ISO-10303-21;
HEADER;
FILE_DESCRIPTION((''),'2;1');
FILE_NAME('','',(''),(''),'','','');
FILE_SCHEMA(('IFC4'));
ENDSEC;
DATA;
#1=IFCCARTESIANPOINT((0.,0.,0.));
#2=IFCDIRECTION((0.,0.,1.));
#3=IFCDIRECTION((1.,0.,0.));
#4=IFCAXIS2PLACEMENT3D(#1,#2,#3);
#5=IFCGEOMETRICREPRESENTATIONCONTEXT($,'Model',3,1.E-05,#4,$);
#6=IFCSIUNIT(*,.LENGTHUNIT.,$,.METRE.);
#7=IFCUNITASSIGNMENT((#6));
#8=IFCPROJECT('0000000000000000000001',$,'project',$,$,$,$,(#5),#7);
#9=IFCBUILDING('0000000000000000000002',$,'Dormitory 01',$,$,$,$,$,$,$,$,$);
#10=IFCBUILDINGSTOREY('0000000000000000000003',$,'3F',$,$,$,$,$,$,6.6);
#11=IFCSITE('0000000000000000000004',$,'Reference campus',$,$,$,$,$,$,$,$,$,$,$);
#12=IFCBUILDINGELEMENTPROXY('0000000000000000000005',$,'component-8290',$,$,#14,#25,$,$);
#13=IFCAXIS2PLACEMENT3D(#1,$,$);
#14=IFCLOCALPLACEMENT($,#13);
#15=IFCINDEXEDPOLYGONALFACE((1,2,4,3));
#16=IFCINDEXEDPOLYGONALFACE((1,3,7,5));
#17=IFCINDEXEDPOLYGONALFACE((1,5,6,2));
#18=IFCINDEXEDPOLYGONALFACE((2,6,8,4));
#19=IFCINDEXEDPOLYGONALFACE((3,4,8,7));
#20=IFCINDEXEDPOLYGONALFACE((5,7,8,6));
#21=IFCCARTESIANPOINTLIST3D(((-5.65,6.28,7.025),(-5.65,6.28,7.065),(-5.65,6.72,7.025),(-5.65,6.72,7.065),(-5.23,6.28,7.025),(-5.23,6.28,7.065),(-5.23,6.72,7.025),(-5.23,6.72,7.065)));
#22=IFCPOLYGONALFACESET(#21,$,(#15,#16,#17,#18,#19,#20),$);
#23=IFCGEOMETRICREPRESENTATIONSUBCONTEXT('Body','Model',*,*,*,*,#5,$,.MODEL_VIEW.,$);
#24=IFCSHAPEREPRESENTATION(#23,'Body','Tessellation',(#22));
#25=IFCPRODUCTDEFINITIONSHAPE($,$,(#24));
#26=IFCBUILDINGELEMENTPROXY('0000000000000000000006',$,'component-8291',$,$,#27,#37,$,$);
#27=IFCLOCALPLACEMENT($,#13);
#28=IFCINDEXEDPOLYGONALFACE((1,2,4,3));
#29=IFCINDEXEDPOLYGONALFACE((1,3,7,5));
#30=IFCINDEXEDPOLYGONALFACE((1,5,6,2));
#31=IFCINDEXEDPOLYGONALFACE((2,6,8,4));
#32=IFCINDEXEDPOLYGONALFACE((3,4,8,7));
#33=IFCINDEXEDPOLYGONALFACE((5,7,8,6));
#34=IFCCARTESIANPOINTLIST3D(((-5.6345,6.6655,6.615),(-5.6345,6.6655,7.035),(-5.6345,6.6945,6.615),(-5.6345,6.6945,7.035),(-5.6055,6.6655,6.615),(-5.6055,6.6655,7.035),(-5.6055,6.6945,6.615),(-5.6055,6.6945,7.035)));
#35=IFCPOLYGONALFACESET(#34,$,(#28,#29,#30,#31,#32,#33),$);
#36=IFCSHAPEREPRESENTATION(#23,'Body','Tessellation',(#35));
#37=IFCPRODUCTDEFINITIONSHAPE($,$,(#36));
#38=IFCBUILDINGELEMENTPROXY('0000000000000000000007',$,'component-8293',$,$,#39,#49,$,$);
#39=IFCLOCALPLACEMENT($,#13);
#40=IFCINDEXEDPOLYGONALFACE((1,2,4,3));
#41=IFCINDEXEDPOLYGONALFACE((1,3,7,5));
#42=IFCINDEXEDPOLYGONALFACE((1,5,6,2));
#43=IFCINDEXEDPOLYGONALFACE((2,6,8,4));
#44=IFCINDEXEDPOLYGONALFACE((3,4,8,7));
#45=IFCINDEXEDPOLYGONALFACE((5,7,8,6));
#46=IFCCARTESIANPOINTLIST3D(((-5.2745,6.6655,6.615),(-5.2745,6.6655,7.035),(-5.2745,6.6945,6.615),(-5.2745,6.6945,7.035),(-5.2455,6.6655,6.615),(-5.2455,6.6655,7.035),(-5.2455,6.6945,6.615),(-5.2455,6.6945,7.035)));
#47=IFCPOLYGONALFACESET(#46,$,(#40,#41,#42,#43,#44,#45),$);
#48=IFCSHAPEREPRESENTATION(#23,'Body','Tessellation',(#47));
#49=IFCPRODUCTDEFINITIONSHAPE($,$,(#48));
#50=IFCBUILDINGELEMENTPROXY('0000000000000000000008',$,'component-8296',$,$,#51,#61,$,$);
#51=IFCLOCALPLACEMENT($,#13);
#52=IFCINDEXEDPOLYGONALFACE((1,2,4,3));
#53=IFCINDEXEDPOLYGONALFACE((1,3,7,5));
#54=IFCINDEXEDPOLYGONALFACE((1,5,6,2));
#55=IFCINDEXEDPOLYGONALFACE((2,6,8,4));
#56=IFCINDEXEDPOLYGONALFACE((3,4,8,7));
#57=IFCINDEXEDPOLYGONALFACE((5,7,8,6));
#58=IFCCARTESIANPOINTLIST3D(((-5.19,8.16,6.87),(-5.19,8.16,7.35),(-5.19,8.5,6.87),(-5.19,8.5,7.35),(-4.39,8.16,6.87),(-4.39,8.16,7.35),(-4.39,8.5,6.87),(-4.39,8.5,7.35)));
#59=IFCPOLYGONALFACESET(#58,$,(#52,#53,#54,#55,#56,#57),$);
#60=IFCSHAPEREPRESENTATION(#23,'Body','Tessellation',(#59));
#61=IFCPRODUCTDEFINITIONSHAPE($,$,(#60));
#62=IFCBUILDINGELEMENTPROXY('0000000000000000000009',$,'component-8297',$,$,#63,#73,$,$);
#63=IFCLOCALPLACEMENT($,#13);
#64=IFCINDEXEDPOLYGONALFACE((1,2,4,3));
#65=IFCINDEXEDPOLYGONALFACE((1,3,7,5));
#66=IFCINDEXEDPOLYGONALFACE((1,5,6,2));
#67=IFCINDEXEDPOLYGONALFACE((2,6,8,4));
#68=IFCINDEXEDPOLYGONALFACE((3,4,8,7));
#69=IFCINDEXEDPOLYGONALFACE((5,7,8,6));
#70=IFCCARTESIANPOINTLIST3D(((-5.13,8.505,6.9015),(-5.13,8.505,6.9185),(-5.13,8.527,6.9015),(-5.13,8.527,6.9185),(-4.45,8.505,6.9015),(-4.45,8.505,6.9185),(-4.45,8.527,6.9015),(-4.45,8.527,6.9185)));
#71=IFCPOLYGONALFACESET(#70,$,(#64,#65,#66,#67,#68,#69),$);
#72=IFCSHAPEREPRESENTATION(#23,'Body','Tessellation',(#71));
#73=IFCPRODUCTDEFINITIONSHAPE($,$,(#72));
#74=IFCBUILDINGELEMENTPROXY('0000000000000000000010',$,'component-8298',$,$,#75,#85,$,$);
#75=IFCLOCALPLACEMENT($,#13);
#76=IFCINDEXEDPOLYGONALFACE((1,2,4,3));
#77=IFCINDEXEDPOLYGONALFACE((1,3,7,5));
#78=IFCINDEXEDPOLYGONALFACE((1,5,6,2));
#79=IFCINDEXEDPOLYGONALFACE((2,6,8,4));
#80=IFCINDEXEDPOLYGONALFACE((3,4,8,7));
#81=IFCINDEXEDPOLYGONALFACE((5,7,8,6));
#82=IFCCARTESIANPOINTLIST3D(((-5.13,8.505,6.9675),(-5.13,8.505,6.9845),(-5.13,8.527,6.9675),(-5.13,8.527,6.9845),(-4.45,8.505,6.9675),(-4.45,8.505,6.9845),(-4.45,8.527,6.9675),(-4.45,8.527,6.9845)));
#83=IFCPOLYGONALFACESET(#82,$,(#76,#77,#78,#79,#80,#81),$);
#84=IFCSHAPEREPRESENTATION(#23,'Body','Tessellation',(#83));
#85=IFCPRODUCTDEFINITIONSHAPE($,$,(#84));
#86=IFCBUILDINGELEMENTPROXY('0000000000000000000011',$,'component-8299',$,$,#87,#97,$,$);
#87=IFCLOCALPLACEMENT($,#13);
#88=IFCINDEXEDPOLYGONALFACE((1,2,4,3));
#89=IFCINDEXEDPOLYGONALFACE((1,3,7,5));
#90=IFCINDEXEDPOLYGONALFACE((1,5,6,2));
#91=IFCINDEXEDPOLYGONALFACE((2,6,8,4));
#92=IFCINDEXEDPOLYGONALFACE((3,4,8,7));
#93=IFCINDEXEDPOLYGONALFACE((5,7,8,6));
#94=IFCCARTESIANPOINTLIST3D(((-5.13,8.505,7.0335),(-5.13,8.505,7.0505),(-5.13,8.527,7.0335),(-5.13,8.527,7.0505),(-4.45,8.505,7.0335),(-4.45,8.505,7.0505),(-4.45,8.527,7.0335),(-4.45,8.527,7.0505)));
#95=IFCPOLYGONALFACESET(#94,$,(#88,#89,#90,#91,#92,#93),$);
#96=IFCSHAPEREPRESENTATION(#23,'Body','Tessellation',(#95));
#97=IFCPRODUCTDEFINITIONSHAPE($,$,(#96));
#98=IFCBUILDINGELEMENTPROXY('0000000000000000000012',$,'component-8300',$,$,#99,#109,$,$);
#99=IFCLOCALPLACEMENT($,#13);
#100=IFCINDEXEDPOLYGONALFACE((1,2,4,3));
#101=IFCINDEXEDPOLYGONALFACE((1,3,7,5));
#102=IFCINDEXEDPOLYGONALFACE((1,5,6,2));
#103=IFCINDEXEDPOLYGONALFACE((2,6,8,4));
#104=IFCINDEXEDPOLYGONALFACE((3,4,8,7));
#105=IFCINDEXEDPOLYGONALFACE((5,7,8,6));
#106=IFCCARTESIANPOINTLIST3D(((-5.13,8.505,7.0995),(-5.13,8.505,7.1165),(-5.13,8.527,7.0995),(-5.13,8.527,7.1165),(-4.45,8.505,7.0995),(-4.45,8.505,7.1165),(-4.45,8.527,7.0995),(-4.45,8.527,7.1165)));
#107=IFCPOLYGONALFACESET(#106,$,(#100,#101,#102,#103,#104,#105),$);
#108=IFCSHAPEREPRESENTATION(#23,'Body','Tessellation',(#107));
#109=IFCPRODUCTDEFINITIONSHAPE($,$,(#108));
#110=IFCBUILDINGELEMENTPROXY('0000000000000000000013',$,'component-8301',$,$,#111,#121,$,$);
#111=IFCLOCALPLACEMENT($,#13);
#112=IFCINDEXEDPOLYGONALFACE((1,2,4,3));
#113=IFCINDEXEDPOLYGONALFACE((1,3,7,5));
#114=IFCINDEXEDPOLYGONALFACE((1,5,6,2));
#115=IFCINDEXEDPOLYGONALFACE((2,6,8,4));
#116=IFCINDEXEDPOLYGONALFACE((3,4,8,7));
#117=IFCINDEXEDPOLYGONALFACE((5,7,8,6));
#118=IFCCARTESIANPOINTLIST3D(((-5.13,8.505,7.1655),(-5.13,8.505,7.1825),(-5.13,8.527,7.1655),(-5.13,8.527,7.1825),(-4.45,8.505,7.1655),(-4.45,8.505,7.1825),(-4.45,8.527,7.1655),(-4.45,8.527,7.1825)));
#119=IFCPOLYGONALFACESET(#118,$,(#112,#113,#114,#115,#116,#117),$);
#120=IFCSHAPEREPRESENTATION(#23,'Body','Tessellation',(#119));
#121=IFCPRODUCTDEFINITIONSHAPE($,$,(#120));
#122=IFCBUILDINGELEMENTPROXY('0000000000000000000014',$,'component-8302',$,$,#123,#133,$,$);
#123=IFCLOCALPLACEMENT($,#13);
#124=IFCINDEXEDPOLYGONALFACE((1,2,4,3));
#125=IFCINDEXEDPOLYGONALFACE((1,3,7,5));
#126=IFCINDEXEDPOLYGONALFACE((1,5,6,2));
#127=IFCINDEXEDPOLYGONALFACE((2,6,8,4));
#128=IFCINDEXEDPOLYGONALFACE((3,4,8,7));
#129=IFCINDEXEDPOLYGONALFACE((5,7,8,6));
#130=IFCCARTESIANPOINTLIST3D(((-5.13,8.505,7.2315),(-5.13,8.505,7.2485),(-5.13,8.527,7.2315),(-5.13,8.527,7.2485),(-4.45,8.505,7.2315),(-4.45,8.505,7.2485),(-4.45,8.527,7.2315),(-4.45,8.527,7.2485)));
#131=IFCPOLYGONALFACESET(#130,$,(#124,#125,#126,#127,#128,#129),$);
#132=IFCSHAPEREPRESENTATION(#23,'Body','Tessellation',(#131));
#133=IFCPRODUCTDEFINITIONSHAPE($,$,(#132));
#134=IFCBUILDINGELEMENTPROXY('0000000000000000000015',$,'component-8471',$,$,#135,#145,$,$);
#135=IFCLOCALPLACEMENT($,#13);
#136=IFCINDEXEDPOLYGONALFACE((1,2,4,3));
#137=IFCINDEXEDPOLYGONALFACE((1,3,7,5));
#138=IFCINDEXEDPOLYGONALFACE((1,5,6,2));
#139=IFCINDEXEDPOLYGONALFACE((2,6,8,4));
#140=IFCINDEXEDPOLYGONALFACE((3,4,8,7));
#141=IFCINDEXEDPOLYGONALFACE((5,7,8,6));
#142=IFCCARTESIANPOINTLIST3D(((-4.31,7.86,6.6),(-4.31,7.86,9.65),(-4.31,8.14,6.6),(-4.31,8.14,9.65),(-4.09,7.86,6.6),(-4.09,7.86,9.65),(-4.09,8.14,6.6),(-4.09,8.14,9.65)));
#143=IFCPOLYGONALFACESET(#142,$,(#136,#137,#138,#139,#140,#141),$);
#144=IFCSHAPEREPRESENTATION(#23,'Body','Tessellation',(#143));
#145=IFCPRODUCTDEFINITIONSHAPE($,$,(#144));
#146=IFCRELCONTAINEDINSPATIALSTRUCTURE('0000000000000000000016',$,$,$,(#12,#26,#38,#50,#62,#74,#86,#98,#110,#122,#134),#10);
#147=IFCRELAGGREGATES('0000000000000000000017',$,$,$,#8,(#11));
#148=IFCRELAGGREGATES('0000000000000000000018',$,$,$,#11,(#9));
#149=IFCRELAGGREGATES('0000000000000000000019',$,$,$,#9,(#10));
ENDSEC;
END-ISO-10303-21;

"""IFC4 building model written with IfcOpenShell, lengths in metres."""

from ifc_helpers import new_model, si_unit, frame, origin, origin_with_axes, origin_2d, place, context, subcontext, project, spatial, rectangle, extrude, element, save


model = new_model("IFC4")

# Units and contexts
model_context = context("Model", 3, precision=1e-05, world=origin_with_axes())
body_context = subcontext(model_context, "Body", "Model", "MODEL_VIEW")
ifc_project = project(units=[si_unit("LENGTHUNIT", "METRE")], contexts=[model_context])

# Site, building, storey
site = spatial("IfcSite", under=ifc_project, Name="Reference campus")
building = spatial("IfcBuilding", under=site, Name="Dormitory 01")
storey = spatial("IfcBuildingStorey", under=building, Name="3F", Elevation=6.6)

# Building element proxies
proxy_1_placement = place(None, frame((-5.44, 6.5, 7.025), z_axis=(0.0, 0.0, 1.0), x_axis=(1.0, 0.0, 0.0)))
element("IfcBuildingElementProxy", 1, at=proxy_1_placement, inside=storey, Name="component-8290", context=body_context, shape_type="SweptSolid", body=[
    extrude(rectangle(XDim=0.42, YDim=0.44, at=origin_2d()), origin(), (0.0, 0.0, 1.0), 0.04),
])
for number, where, z_axis, x_axis, name in (
    (2, (-5.62, 6.68, 6.615), (0.0, 0.0, 1.0), (1.0, 0.0, 0.0), "component-8291"),
    (3, (-5.26, 6.68, 6.615), (0.0, 0.0, 1.0), (1.0, 0.0, 0.0), "component-8293"),
):
    element("IfcBuildingElementProxy", number, at=place(None, frame(where, z_axis=z_axis, x_axis=x_axis)), inside=storey, Name=name, context=body_context, shape_type="SweptSolid", body=[
        extrude(rectangle(XDim=0.029, YDim=0.029, at=origin_2d()), origin(), (0.0, 0.0, 1.0), 0.42),
    ])
proxy_2_placement = place(None, frame((-4.79, 8.33, 6.87), z_axis=(0.0, 0.0, 1.0), x_axis=(1.0, 0.0, 0.0)))
element("IfcBuildingElementProxy", 4, at=proxy_2_placement, inside=storey, Name="component-8296", context=body_context, shape_type="SweptSolid", body=[
    extrude(rectangle(XDim=0.8, YDim=0.34, at=origin_2d()), origin(), (0.0, 0.0, 1.0), 0.48),
])
for number, where, z_axis, x_axis, name in (
    (5, (-4.79, 8.516, 6.9015), (0.0, 0.0, 1.0), (1.0, 0.0, 0.0), "component-8297"),
    (6, (-4.79, 8.516, 6.9675), (0.0, 0.0, 1.0), (1.0, 0.0, 0.0), "component-8298"),
    (7, (-4.79, 8.516, 7.0335), (0.0, 0.0, 1.0), (1.0, 0.0, 0.0), "component-8299"),
    (8, (-4.79, 8.516, 7.0995), (0.0, 0.0, 1.0), (1.0, 0.0, 0.0), "component-8300"),
    (9, (-4.79, 8.516, 7.1655), (0.0, 0.0, 1.0), (1.0, 0.0, 0.0), "component-8301"),
    (10, (-4.79, 8.516, 7.2315), (0.0, 0.0, 1.0), (1.0, 0.0, 0.0), "component-8302"),
):
    element("IfcBuildingElementProxy", number, at=place(None, frame(where, z_axis=z_axis, x_axis=x_axis)), inside=storey, Name=name, context=body_context, shape_type="SweptSolid", body=[
        extrude(rectangle(XDim=0.68, YDim=0.022, at=origin_2d()), origin(), (0.0, 0.0, 1.0), 0.017),
    ])
proxy_3_placement = place(None, frame((-4.2, 8.0, 6.6), z_axis=(0.0, 0.0, 1.0), x_axis=(1.0, 0.0, 0.0)))
element("IfcBuildingElementProxy", 11, at=proxy_3_placement, inside=storey, Name="component-8471", context=body_context, shape_type="SweptSolid", body=[
    extrude(rectangle(XDim=0.22, YDim=0.28, at=origin_2d()), origin(), (0.0, 0.0, 1.0), 3.05),
])

save(model, "model.ifc")
